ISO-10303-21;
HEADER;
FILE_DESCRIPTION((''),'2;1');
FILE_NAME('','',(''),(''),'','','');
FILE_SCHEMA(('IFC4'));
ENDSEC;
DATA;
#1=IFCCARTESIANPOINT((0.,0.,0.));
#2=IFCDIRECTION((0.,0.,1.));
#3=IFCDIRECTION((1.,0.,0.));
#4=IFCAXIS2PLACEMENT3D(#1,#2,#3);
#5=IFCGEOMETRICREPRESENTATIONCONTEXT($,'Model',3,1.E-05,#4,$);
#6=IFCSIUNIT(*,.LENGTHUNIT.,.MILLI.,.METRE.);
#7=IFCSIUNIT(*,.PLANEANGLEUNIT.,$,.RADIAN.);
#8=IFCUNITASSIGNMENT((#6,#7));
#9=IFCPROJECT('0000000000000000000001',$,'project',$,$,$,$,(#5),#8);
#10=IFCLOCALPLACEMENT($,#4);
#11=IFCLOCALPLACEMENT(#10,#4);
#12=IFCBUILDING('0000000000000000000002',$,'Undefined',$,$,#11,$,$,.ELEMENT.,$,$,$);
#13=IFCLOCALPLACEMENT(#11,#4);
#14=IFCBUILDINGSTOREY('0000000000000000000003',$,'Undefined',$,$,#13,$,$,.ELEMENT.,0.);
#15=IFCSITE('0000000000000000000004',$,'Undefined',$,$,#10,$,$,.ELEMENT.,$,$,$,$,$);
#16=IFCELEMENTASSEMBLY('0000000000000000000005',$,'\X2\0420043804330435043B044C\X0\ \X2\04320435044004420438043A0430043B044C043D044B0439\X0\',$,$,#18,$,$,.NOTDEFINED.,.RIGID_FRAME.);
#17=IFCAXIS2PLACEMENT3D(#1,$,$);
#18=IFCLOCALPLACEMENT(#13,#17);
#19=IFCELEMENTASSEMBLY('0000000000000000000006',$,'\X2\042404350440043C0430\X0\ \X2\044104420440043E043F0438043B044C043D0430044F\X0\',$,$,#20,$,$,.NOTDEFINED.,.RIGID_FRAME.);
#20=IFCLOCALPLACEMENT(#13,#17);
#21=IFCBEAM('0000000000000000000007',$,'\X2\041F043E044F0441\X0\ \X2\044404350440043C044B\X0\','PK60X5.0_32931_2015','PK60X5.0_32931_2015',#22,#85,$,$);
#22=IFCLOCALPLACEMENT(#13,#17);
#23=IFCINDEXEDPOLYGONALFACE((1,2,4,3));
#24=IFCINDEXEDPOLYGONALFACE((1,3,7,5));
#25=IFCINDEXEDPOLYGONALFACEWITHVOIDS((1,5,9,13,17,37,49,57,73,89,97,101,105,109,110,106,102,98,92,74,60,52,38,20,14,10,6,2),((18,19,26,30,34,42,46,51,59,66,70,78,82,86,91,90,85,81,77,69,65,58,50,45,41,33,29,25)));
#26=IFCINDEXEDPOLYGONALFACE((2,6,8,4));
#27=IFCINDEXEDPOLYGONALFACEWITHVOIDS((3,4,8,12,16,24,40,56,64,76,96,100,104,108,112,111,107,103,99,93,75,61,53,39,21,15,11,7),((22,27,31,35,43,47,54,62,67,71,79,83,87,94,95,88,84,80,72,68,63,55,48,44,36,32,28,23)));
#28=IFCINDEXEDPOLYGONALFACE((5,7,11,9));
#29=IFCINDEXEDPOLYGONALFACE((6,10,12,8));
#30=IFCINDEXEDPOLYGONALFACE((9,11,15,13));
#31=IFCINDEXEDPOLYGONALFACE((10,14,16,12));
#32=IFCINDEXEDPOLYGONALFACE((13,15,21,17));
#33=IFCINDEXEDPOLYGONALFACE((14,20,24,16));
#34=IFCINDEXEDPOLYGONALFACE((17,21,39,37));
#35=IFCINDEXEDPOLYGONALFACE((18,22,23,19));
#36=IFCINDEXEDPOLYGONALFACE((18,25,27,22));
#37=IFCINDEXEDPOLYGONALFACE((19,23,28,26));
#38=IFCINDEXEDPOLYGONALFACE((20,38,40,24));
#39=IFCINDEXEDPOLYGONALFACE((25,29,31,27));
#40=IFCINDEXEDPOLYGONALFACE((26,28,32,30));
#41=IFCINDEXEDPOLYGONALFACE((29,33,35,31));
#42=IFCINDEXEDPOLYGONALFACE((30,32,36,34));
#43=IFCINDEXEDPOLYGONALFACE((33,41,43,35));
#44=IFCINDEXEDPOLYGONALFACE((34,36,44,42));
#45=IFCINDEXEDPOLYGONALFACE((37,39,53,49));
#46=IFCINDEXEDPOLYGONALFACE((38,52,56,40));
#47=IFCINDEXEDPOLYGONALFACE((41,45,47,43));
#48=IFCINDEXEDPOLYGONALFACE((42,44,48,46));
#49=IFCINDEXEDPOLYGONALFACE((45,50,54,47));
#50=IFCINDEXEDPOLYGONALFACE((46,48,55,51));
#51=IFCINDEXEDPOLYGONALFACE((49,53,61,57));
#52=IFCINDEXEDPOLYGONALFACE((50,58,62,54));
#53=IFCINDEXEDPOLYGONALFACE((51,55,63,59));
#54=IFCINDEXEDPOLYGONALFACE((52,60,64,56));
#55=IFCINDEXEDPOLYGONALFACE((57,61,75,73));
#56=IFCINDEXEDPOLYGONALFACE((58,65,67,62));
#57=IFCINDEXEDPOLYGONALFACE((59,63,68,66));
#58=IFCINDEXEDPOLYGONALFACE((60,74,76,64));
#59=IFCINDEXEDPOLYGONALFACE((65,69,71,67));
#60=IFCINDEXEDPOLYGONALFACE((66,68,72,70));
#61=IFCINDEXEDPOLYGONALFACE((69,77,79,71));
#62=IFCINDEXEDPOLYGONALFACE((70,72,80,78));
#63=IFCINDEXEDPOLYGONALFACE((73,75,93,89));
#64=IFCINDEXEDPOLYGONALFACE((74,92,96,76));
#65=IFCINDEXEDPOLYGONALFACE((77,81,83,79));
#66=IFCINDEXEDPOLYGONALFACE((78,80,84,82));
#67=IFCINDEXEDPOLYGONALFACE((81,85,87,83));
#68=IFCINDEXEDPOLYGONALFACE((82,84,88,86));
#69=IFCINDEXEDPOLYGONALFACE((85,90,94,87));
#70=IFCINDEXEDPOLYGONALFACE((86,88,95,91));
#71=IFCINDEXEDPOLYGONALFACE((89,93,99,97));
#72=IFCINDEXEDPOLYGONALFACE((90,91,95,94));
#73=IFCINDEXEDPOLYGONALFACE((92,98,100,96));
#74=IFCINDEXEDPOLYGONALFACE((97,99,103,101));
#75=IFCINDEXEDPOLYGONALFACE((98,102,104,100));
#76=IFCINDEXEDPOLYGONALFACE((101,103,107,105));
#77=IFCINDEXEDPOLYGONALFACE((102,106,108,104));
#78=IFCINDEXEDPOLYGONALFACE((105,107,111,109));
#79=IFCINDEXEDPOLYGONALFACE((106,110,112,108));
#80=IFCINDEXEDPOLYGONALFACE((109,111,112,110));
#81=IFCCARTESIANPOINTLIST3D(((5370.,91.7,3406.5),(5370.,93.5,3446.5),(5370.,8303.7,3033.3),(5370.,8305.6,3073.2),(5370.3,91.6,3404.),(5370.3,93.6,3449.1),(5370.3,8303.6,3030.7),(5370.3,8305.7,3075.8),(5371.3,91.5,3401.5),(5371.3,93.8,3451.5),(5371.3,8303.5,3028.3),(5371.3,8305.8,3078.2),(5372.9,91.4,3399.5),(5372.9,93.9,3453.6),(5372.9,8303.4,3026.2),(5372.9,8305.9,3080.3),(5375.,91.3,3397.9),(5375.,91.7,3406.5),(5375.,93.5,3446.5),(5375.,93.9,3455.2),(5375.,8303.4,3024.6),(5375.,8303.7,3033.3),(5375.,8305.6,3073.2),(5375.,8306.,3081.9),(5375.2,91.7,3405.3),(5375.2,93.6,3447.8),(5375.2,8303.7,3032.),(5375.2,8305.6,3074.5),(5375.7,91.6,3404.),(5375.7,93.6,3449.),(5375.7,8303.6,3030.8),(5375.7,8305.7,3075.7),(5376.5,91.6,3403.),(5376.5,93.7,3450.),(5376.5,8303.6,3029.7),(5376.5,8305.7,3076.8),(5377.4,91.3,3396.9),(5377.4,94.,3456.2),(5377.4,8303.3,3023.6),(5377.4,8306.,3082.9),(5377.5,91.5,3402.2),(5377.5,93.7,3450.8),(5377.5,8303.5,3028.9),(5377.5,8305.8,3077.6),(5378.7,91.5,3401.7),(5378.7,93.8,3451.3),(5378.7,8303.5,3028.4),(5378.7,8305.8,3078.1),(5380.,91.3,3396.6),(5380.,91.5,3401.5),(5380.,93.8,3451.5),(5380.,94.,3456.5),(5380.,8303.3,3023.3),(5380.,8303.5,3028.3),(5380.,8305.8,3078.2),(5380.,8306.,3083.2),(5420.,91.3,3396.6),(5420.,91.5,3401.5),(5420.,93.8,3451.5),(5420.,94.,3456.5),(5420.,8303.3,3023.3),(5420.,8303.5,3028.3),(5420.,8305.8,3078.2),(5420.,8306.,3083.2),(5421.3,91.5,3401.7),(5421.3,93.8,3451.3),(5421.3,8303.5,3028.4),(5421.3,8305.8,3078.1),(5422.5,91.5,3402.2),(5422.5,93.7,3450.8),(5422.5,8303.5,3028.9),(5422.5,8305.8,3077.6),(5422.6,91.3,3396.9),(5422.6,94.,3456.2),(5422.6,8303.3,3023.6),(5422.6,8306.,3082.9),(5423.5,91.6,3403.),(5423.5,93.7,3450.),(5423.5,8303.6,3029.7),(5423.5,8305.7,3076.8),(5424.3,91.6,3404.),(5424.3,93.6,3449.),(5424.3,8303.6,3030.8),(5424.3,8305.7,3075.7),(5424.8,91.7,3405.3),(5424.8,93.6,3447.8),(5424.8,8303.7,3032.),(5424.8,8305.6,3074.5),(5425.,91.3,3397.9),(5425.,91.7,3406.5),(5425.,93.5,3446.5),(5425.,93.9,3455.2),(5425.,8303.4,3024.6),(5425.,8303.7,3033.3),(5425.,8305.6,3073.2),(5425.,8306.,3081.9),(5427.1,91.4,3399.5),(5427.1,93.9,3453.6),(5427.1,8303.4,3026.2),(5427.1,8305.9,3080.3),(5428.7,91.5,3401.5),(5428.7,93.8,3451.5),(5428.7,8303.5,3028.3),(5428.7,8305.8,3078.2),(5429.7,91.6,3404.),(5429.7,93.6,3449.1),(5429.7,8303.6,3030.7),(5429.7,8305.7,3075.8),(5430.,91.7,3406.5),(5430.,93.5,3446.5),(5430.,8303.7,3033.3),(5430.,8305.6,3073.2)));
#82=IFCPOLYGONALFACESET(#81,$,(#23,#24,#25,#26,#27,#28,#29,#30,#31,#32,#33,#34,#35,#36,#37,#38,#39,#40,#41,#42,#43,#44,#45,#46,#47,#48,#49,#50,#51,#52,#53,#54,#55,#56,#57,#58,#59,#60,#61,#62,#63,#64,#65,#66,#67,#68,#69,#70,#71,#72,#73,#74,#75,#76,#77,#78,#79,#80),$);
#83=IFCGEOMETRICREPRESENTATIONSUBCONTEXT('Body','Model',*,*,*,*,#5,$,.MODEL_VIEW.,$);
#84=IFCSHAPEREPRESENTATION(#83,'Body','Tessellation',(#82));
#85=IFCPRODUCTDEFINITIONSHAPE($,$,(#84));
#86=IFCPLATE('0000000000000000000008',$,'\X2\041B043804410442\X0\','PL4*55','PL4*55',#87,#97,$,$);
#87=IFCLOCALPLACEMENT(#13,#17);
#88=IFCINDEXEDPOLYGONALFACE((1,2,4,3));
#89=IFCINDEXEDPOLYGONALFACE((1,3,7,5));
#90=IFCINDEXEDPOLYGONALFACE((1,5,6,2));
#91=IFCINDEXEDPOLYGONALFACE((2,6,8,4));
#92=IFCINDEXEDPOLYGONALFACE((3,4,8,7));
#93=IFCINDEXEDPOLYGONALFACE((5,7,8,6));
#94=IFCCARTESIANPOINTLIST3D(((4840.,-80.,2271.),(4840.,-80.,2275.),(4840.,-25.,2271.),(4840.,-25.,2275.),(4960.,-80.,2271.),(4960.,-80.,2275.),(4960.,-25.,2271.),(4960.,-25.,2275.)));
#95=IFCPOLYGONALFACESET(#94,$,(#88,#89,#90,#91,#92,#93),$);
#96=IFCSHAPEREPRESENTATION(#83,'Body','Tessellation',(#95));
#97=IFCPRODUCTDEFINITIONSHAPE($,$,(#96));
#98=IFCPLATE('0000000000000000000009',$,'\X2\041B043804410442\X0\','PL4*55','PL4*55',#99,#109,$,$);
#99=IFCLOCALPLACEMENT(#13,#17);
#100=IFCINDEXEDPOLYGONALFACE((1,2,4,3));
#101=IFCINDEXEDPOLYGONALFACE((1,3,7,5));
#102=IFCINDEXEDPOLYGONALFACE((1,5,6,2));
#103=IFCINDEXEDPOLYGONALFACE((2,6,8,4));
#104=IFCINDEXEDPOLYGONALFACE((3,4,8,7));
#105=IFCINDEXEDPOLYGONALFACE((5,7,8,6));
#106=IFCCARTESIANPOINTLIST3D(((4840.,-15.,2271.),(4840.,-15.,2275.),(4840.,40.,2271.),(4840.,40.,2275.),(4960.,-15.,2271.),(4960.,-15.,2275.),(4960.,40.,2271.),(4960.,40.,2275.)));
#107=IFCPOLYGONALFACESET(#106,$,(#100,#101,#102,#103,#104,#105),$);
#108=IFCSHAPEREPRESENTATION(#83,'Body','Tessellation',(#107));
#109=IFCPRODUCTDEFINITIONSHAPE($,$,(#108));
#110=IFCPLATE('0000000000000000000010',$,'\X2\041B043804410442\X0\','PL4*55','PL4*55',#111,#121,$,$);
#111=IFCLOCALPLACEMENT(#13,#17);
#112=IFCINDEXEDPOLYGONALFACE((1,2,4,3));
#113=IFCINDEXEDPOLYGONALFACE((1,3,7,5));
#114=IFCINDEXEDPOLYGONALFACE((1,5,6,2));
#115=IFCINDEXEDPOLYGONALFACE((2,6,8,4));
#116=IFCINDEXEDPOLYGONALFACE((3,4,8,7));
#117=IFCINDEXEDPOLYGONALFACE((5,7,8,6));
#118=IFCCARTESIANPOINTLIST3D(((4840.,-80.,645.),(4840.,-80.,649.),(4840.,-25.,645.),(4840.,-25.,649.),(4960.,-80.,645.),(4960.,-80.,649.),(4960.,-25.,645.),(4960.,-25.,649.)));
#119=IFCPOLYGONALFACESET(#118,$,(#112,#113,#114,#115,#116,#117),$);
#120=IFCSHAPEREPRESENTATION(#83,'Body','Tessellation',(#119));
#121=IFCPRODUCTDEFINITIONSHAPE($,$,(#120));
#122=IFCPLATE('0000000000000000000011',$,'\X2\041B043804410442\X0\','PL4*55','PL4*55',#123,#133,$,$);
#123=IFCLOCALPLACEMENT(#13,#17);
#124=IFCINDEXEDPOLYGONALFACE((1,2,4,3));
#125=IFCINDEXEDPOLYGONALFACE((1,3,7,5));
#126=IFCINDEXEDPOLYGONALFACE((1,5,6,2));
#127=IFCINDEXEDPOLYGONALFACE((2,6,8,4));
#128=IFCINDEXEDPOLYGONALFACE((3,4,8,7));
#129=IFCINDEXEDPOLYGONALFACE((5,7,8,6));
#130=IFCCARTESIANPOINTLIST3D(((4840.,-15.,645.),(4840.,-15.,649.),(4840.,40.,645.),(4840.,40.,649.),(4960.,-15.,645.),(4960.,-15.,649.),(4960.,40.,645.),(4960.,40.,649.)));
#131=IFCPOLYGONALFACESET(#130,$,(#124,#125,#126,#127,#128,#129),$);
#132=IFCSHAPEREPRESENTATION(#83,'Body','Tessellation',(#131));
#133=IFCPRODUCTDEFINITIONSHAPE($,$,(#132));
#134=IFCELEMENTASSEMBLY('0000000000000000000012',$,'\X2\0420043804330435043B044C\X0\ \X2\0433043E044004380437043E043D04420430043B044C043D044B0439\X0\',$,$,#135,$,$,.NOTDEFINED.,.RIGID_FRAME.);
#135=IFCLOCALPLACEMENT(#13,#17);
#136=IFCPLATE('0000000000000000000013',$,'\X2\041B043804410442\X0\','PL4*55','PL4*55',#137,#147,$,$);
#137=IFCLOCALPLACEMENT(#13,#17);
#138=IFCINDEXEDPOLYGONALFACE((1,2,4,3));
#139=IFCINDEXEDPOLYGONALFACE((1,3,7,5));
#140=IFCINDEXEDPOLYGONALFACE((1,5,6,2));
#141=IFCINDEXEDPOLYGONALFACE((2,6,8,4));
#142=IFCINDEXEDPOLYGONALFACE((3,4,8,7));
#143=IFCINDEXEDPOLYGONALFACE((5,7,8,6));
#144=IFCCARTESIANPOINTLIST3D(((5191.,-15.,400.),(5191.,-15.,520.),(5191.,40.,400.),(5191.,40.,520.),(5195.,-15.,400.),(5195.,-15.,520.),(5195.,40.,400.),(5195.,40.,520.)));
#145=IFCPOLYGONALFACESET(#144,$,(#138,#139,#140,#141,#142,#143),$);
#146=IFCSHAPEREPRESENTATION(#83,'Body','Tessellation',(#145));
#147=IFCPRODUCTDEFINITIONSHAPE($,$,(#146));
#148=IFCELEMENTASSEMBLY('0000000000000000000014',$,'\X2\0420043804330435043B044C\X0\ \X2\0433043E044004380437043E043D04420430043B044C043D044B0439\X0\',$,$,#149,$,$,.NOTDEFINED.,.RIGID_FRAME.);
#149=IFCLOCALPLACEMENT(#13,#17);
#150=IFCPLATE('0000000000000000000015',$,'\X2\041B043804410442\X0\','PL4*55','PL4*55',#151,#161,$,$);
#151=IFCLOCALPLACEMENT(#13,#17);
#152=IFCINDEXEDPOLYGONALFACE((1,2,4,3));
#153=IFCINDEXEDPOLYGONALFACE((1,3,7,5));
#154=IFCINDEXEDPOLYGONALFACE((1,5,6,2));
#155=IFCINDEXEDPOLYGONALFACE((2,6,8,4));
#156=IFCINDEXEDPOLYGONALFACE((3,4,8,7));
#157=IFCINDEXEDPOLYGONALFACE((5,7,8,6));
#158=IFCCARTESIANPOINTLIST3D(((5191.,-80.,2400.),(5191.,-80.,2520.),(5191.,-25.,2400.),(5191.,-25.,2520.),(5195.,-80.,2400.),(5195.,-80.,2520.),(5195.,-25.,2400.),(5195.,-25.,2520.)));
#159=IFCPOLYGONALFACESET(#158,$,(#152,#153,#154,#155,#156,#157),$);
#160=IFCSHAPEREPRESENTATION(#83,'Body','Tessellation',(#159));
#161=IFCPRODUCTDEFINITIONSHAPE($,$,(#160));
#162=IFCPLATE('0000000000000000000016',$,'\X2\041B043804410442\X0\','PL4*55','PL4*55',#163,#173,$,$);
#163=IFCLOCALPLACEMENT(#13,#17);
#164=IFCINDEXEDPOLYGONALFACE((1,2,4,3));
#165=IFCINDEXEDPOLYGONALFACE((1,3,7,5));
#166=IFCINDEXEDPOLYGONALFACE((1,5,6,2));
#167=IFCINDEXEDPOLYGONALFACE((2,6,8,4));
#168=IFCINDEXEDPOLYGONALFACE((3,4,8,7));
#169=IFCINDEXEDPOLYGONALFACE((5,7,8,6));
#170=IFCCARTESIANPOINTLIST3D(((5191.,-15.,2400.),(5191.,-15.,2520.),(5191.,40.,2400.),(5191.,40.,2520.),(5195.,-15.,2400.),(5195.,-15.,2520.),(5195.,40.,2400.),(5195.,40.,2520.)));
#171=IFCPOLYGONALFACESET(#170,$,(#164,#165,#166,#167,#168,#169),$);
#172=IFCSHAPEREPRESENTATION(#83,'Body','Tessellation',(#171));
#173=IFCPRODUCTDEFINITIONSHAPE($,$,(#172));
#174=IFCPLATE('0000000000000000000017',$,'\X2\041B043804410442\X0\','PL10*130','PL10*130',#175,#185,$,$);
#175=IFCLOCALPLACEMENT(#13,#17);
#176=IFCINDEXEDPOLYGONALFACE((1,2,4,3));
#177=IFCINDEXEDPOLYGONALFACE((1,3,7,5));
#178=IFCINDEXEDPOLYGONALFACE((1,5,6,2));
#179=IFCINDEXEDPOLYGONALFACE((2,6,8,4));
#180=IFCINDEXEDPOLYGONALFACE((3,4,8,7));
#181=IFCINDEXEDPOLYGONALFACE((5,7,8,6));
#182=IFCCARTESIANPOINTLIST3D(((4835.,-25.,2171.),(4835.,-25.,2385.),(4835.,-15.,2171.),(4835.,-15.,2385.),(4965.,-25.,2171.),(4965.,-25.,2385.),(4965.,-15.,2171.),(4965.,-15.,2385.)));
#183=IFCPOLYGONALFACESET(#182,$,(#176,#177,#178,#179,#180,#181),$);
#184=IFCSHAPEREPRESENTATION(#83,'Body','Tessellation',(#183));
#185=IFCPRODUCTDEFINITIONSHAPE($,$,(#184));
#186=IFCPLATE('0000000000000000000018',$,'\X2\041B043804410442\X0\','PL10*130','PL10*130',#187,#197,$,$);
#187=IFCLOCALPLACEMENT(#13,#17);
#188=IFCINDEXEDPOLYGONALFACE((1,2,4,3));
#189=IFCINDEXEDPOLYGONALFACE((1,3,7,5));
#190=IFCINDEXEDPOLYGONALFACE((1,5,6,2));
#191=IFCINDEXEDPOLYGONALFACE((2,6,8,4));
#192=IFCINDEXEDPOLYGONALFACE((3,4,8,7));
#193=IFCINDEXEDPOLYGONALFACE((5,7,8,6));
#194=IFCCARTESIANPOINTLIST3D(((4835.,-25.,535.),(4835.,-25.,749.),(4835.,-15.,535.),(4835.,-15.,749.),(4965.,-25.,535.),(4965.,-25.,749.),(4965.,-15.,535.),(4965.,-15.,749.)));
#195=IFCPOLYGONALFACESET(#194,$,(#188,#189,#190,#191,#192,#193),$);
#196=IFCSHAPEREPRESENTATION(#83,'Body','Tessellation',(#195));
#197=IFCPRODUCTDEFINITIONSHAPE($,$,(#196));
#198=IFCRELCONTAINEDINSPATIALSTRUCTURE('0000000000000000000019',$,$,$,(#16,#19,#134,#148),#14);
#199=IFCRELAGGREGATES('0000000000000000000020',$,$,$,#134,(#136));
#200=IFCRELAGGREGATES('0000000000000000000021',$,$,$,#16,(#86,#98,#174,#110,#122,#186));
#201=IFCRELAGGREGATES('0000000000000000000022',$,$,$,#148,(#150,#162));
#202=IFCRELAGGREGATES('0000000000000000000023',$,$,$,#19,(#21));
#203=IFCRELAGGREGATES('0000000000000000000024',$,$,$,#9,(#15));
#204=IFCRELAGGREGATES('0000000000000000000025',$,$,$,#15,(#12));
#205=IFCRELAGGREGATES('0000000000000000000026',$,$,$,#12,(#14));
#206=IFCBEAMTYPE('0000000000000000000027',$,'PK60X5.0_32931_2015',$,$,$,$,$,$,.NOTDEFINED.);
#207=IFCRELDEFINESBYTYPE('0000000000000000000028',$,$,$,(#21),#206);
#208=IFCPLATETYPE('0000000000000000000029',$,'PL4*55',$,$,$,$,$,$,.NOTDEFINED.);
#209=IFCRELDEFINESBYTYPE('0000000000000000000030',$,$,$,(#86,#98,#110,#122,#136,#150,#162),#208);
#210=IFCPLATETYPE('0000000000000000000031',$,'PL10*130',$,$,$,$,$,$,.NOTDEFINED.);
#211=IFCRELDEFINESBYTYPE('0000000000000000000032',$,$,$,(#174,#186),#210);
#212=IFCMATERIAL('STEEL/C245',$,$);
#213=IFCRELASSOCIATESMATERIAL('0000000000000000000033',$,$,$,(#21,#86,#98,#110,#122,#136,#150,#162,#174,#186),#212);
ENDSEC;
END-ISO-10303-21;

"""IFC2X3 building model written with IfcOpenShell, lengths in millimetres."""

from ifc_helpers import new_model, si_unit, frame, origin_with_axes, origin_2d_with_axis, place, context, subcontext, project, spatial, polyline, hollow_rectangle, outline, extrude, clip, halfspace, material, type_object, element, aggregate, save


model = new_model("IFC2X3")

# Units and contexts
model_context = context("Model", 3, precision=1e-05, world=origin_with_axes())
body_context = subcontext(model_context, "Body", "Model", "MODEL_VIEW")
ifc_project = project(units=[si_unit("LENGTHUNIT", "METRE", prefix="MILLI"), si_unit("PLANEANGLEUNIT", "RADIAN")], contexts=[model_context])

# Site, building, storey
site_placement = place(None, origin_with_axes())
site = spatial("IfcSite", under=ifc_project, at=site_placement, Name="Undefined", CompositionType="ELEMENT")
building_placement = place(site_placement, origin_with_axes())
building = spatial("IfcBuilding", under=site, at=building_placement, Name="Undefined", CompositionType="ELEMENT")
storey_placement = place(building_placement, origin_with_axes())
storey = spatial("IfcBuildingStorey", under=building, at=storey_placement, Name="Undefined", CompositionType="ELEMENT", Elevation=0.0)

# Element assembly
assembly_1_placement = place(storey_placement, origin_with_axes())
assembly_1 = element("IfcElementAssembly", 1, at=assembly_1_placement, inside=storey, Name="Ригель вертикальный", AssemblyPlace="NOTDEFINED", PredefinedType="RIGID_FRAME")
ifc_material_1 = material(Name="STEEL/C245")

# Element assembly, beam
assembly_2_placement = place(storey_placement, origin_with_axes())
assembly_2 = element("IfcElementAssembly", 2, at=assembly_2_placement, inside=storey, Name="Ферма стропильная", AssemblyPlace="NOTDEFINED", PredefinedType="RIGID_FRAME")
beam_type_1 = type_object("IfcBeamType", Name="PK60X5.0_32931_2015", PredefinedType="NOTDEFINED")
beam_1_placement = place(assembly_2_placement, frame((5400.0, 88.6, 3426.7), z_axis=(0.0, 0.045408, 0.998969), x_axis=(0.0, 0.998969, -0.045408)))
beam_1 = element("IfcBeam", 3, at=beam_1_placement, type_object=beam_type_1, material=ifc_material_1, Name="Пояс фермы", Description="PK60X5.0_32931_2015", ObjectType="PK60X5.0_32931_2015", context=body_context, shape_type="Clipping", body=[
    clip(clip(extrude(hollow_rectangle(XDim=60.0, YDim=60.0, WallThickness=5.0, InnerFilletRadius=5.0, OuterFilletRadius=10.0, at=origin_2d_with_axis()), frame((8230.0, 0.0, 0.0), z_axis=(-1.0, 0.0, 0.0), x_axis=(0.0, -1.0, 0.0)), (0.0, 0.0, 1.0), 8231.5), halfspace(frame((8224.5, 0.0, -30.0), z_axis=(-1.0, 0.0, 0.0), x_axis=(0.0, 1.0, 0.0)), True)), halfspace(frame((4.0, 0.0, -30.0), z_axis=(1.0, 0.0, 0.0), x_axis=(0.0, -1.0, 0.0)), True)),
])

# Plates
plate_type_1 = type_object("IfcPlateType", Name="PL4*55", PredefinedType="NOTDEFINED")
plate_1_placement = place(assembly_1_placement, frame((4960.0, -52.5, 2273.0), z_axis=(0.0, 0.0, -1.0), x_axis=(-1.0, 0.0, 0.0)))
plate_1 = element("IfcPlate", 4, at=plate_1_placement, type_object=plate_type_1, material=ifc_material_1, Name="Лист", Description="PL4*55", ObjectType="PL4*55", context=body_context, shape_type="SweptSolid", body=[
    extrude(outline(polyline([(120.0, -27.5), (0.0, -27.5), (0.0, 27.5), (120.0, 27.5), (120.0, -27.5)])), frame((0.0, 0.0, -2.0), z_axis=(0.0, 0.0, 1.0), x_axis=(1.0, 0.0, 0.0)), (0.0, 0.0, 1.0), 4.0),
])
plate_2_placement = place(assembly_1_placement, frame((4960.0, 12.5, 2273.0), z_axis=(0.0, 0.0, 1.0), x_axis=(-1.0, 0.0, 0.0)))
plate_2 = element("IfcPlate", 5, at=plate_2_placement, type_object=plate_type_1, material=ifc_material_1, Name="Лист", Description="PL4*55", ObjectType="PL4*55", context=body_context, shape_type="SweptSolid", body=[
    extrude(outline(polyline([(120.0, 27.5), (120.0, -27.5), (0.0, -27.5), (0.0, 27.5), (120.0, 27.5)])), frame((0.0, 0.0, -2.0), z_axis=(0.0, 0.0, 1.0), x_axis=(1.0, 0.0, 0.0)), (0.0, 0.0, 1.0), 4.0),
])
plate_3_placement = place(assembly_1_placement, frame((4840.0, -52.5, 647.0), z_axis=(0.0, 0.0, 1.0), x_axis=(1.0, 0.0, 0.0)))
plate_3 = element("IfcPlate", 6, at=plate_3_placement, type_object=plate_type_1, material=ifc_material_1, Name="Лист", Description="PL4*55", ObjectType="PL4*55", context=body_context, shape_type="SweptSolid", body=[
    extrude(outline(polyline([(0.0, -27.5), (0.0, 27.5), (120.0, 27.5), (120.0, -27.5), (0.0, -27.5)])), frame((0.0, 0.0, -2.0), z_axis=(0.0, 0.0, 1.0), x_axis=(1.0, 0.0, 0.0)), (0.0, 0.0, 1.0), 4.0),
])
plate_4_placement = place(assembly_1_placement, frame((4840.0, 12.5, 647.0), z_axis=(0.0, 0.0, -1.0), x_axis=(1.0, 0.0, 0.0)))
plate_4 = element("IfcPlate", 7, at=plate_4_placement, type_object=plate_type_1, material=ifc_material_1, Name="Лист", Description="PL4*55", ObjectType="PL4*55", context=body_context, shape_type="SweptSolid", body=[
    extrude(outline(polyline([(0.0, 27.5), (120.0, 27.5), (120.0, -27.5), (0.0, -27.5), (0.0, 27.5)])), frame((0.0, 0.0, -2.0), z_axis=(0.0, 0.0, 1.0), x_axis=(1.0, 0.0, 0.0)), (0.0, 0.0, 1.0), 4.0),
])

# Element assembly, plate
assembly_3_placement = place(storey_placement, origin_with_axes())
assembly_3 = element("IfcElementAssembly", 8, at=assembly_3_placement, inside=storey, Name="Ригель горизонтальный", AssemblyPlace="NOTDEFINED", PredefinedType="RIGID_FRAME")
plate_5_placement = place(assembly_3_placement, frame((5193.0, 12.5, 520.0), z_axis=(-1.0, 0.0, 0.0), x_axis=(0.0, 0.0, -1.0)))
plate_5 = element("IfcPlate", 9, at=plate_5_placement, type_object=plate_type_1, material=ifc_material_1, Name="Лист", Description="PL4*55", ObjectType="PL4*55", context=body_context, shape_type="SweptSolid", body=[
    extrude(outline(polyline([(120.0, 27.5), (120.0, -27.5), (0.0, -27.5), (0.0, 27.5), (120.0, 27.5)])), frame((0.0, 0.0, -2.0), z_axis=(0.0, 0.0, 1.0), x_axis=(1.0, 0.0, 0.0)), (0.0, 0.0, 1.0), 4.0),
])
aggregate(assembly_3, [plate_5])

# Element assembly, plates
assembly_4_placement = place(storey_placement, origin_with_axes())
assembly_4 = element("IfcElementAssembly", 10, at=assembly_4_placement, inside=storey, Name="Ригель горизонтальный", AssemblyPlace="NOTDEFINED", PredefinedType="RIGID_FRAME")
plate_6_placement = place(assembly_4_placement, frame((5193.0, -52.5, 2400.0), z_axis=(-1.0, 0.0, 0.0), x_axis=(0.0, 0.0, 1.0)))
plate_6 = element("IfcPlate", 11, at=plate_6_placement, type_object=plate_type_1, material=ifc_material_1, Name="Лист", Description="PL4*55", ObjectType="PL4*55", context=body_context, shape_type="SweptSolid", body=[
    extrude(outline(polyline([(0.0, -27.5), (0.0, 27.5), (120.0, 27.5), (120.0, -27.5), (0.0, -27.5)])), frame((0.0, 0.0, -2.0), z_axis=(0.0, 0.0, 1.0), x_axis=(1.0, 0.0, 0.0)), (0.0, 0.0, 1.0), 4.0),
])
plate_7_placement = place(assembly_4_placement, frame((5193.0, 12.5, 2400.0), z_axis=(1.0, 0.0, 0.0), x_axis=(0.0, 0.0, 1.0)))
plate_7 = element("IfcPlate", 12, at=plate_7_placement, type_object=plate_type_1, material=ifc_material_1, Name="Лист", Description="PL4*55", ObjectType="PL4*55", context=body_context, shape_type="SweptSolid", body=[
    extrude(outline(polyline([(0.0, 27.5), (120.0, 27.5), (120.0, -27.5), (0.0, -27.5), (0.0, 27.5)])), frame((0.0, 0.0, -2.0), z_axis=(0.0, 0.0, 1.0), x_axis=(1.0, 0.0, 0.0)), (0.0, 0.0, 1.0), 4.0),
])

# Plates
plate_type_2 = type_object("IfcPlateType", Name="PL10*130", PredefinedType="NOTDEFINED")
plate_8_placement = place(assembly_1_placement, frame((4900.0, -20.0, 2385.0), z_axis=(0.0, -1.0, 0.0), x_axis=(0.0, 0.0, -1.0)))
plate_8 = element("IfcPlate", 13, at=plate_8_placement, type_object=plate_type_2, material=ifc_material_1, Name="Лист", Description="PL10*130", ObjectType="PL10*130", context=body_context, shape_type="SweptSolid", body=[
    extrude(outline(polyline([(214.0, -65.0), (0.0, -65.0), (0.0, 65.0), (214.0, 65.0), (214.0, -65.0)])), frame((0.0, 0.0, -5.0), z_axis=(0.0, 0.0, 1.0), x_axis=(1.0, 0.0, 0.0)), (0.0, 0.0, 1.0), 10.0),
])
plate_9_placement = place(assembly_1_placement, frame((4900.0, -20.0, 535.0), z_axis=(0.0, -1.0, 0.0), x_axis=(0.0, 0.0, 1.0)))
plate_9 = element("IfcPlate", 14, at=plate_9_placement, type_object=plate_type_2, material=ifc_material_1, Name="Лист", Description="PL10*130", ObjectType="PL10*130", context=body_context, shape_type="SweptSolid", body=[
    extrude(outline(polyline([(0.0, 65.0), (214.0, 65.0), (214.0, -65.0), (0.0, -65.0), (0.0, 65.0)])), frame((0.0, 0.0, -5.0), z_axis=(0.0, 0.0, 1.0), x_axis=(1.0, 0.0, 0.0)), (0.0, 0.0, 1.0), 10.0),
])

aggregate(assembly_1, [plate_1, plate_2, plate_8, plate_3, plate_4, plate_9])
aggregate(assembly_4, [plate_6, plate_7])
aggregate(assembly_2, [beam_1])

save(model, "model.ifc")
